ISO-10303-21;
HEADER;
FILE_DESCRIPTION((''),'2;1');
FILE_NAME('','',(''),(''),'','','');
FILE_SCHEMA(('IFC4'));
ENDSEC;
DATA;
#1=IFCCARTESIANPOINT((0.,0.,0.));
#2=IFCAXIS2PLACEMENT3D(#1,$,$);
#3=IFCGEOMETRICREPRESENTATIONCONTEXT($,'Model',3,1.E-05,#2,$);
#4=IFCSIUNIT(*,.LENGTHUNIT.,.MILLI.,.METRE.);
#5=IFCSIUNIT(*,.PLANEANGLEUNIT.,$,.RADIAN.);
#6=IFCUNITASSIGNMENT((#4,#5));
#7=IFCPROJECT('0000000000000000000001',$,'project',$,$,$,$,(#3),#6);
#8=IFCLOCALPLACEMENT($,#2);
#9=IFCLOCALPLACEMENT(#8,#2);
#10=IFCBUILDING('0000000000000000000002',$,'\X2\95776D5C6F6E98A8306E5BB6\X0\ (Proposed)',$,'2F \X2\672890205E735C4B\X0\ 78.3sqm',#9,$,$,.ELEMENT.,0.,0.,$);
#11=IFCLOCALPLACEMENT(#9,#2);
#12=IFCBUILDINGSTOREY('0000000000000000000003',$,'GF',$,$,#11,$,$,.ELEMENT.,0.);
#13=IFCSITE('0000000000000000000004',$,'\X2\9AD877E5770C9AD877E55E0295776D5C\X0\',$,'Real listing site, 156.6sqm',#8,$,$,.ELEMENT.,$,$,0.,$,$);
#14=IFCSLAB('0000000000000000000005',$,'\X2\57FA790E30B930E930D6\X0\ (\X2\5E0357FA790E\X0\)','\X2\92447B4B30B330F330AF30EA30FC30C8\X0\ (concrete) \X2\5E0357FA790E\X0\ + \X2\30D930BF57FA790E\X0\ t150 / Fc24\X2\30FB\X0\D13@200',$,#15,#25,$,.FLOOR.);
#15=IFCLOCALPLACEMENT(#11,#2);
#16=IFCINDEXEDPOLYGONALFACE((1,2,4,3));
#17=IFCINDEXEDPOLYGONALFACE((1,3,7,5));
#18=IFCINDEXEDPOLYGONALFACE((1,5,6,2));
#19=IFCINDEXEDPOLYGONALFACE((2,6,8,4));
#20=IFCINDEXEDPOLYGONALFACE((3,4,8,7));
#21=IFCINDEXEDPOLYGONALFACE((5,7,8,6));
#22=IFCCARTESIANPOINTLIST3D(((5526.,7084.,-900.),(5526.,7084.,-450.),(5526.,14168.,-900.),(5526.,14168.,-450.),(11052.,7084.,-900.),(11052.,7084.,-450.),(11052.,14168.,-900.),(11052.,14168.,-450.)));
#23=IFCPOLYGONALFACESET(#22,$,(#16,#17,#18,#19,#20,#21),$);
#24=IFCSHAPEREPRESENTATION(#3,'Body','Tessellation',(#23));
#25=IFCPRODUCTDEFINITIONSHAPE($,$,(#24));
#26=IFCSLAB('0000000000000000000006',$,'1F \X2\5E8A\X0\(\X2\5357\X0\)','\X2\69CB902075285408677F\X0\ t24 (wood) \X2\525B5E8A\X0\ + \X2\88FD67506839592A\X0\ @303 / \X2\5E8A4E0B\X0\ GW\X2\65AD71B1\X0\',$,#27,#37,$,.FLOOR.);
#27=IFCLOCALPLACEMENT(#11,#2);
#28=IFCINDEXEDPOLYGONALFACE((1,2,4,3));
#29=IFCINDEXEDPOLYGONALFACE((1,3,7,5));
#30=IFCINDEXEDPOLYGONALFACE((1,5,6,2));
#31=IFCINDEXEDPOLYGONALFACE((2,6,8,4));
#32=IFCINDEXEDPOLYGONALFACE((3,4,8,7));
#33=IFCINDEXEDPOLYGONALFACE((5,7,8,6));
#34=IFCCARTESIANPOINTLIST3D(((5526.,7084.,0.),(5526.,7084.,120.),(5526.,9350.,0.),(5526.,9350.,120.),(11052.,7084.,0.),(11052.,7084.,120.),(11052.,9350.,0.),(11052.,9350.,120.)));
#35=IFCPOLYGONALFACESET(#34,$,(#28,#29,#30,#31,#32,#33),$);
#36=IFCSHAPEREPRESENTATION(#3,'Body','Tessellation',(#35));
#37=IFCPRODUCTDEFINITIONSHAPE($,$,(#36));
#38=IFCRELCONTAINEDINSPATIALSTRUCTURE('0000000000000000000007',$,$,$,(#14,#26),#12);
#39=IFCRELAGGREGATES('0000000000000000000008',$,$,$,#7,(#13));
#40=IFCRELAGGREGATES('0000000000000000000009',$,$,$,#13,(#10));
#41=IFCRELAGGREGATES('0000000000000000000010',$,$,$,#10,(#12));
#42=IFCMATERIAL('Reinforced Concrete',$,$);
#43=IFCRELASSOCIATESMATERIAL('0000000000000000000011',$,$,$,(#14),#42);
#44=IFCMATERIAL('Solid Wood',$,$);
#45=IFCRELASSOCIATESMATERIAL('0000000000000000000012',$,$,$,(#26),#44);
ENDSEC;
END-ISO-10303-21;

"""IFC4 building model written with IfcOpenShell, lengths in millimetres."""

from ifc_helpers import new_model, si_unit, frame, frame_2d, origin, place, context, project, spatial, rectangle, extrude, material, element, save


model = new_model("IFC4")

# Units and contexts
model_context = context("Model", 3, precision=1e-05, world=origin())
ifc_project = project(units=[si_unit("LENGTHUNIT", "METRE", prefix="MILLI"), si_unit("PLANEANGLEUNIT", "RADIAN")], contexts=[model_context])

# Site, building, storey
site_placement = place(None, origin())
site = spatial("IfcSite", under=ifc_project, at=site_placement, Name="高知県高知市長浜", ObjectType="Real listing site, 156.6sqm", CompositionType="ELEMENT", RefElevation=0.0)
building_placement = place(site_placement, origin())
building = spatial("IfcBuilding", under=site, at=building_placement, Name="長浜潮風の家 (Proposed)", ObjectType="2F 木造平屋 78.3sqm", CompositionType="ELEMENT", ElevationOfRefHeight=0.0, ElevationOfTerrain=0.0)
storey_placement = place(building_placement, origin())
storey = spatial("IfcBuildingStorey", under=building, at=storey_placement, Name="GF", CompositionType="ELEMENT", Elevation=0.0)

# Slabs
ifc_material_1 = material(Name="Reinforced Concrete")
slab_1_placement = place(storey_placement, frame((2763.0, 3542.0, -450.0)))
element("IfcSlab", 1, at=slab_1_placement, inside=storey, material=ifc_material_1, Name="基礎スラブ (布基礎)", Description="鉄筋コンクリート (concrete) 布基礎 + ベタ基礎 t150 / Fc24・D13@200", PredefinedType="FLOOR", context=model_context, shape_type="SweptSolid", body=[
    extrude(rectangle(XDim=5526.0, YDim=7084.0, at=frame_2d((2763.0, 3542.0))), frame((2763.0, 3542.0, -450.0)), (0.0, 0.0, 1.0), 450.0),
])
ifc_material_2 = material(Name="Solid Wood")
slab_2_placement = place(storey_placement, frame((2763.0, 3542.0, 0.0)))
element("IfcSlab", 2, at=slab_2_placement, inside=storey, material=ifc_material_2, Name="1F 床(南)", Description="構造用合板 t24 (wood) 剛床 + 製材根太 @303 / 床下 GW断熱", PredefinedType="FLOOR", context=model_context, shape_type="SweptSolid", body=[
    extrude(rectangle(XDim=5526.0, YDim=2266.0, at=frame_2d((2763.0, 1133.0))), frame((2763.0, 3542.0, 0.0)), (0.0, 0.0, 1.0), 120.0),
])

save(model, "model.ifc")
